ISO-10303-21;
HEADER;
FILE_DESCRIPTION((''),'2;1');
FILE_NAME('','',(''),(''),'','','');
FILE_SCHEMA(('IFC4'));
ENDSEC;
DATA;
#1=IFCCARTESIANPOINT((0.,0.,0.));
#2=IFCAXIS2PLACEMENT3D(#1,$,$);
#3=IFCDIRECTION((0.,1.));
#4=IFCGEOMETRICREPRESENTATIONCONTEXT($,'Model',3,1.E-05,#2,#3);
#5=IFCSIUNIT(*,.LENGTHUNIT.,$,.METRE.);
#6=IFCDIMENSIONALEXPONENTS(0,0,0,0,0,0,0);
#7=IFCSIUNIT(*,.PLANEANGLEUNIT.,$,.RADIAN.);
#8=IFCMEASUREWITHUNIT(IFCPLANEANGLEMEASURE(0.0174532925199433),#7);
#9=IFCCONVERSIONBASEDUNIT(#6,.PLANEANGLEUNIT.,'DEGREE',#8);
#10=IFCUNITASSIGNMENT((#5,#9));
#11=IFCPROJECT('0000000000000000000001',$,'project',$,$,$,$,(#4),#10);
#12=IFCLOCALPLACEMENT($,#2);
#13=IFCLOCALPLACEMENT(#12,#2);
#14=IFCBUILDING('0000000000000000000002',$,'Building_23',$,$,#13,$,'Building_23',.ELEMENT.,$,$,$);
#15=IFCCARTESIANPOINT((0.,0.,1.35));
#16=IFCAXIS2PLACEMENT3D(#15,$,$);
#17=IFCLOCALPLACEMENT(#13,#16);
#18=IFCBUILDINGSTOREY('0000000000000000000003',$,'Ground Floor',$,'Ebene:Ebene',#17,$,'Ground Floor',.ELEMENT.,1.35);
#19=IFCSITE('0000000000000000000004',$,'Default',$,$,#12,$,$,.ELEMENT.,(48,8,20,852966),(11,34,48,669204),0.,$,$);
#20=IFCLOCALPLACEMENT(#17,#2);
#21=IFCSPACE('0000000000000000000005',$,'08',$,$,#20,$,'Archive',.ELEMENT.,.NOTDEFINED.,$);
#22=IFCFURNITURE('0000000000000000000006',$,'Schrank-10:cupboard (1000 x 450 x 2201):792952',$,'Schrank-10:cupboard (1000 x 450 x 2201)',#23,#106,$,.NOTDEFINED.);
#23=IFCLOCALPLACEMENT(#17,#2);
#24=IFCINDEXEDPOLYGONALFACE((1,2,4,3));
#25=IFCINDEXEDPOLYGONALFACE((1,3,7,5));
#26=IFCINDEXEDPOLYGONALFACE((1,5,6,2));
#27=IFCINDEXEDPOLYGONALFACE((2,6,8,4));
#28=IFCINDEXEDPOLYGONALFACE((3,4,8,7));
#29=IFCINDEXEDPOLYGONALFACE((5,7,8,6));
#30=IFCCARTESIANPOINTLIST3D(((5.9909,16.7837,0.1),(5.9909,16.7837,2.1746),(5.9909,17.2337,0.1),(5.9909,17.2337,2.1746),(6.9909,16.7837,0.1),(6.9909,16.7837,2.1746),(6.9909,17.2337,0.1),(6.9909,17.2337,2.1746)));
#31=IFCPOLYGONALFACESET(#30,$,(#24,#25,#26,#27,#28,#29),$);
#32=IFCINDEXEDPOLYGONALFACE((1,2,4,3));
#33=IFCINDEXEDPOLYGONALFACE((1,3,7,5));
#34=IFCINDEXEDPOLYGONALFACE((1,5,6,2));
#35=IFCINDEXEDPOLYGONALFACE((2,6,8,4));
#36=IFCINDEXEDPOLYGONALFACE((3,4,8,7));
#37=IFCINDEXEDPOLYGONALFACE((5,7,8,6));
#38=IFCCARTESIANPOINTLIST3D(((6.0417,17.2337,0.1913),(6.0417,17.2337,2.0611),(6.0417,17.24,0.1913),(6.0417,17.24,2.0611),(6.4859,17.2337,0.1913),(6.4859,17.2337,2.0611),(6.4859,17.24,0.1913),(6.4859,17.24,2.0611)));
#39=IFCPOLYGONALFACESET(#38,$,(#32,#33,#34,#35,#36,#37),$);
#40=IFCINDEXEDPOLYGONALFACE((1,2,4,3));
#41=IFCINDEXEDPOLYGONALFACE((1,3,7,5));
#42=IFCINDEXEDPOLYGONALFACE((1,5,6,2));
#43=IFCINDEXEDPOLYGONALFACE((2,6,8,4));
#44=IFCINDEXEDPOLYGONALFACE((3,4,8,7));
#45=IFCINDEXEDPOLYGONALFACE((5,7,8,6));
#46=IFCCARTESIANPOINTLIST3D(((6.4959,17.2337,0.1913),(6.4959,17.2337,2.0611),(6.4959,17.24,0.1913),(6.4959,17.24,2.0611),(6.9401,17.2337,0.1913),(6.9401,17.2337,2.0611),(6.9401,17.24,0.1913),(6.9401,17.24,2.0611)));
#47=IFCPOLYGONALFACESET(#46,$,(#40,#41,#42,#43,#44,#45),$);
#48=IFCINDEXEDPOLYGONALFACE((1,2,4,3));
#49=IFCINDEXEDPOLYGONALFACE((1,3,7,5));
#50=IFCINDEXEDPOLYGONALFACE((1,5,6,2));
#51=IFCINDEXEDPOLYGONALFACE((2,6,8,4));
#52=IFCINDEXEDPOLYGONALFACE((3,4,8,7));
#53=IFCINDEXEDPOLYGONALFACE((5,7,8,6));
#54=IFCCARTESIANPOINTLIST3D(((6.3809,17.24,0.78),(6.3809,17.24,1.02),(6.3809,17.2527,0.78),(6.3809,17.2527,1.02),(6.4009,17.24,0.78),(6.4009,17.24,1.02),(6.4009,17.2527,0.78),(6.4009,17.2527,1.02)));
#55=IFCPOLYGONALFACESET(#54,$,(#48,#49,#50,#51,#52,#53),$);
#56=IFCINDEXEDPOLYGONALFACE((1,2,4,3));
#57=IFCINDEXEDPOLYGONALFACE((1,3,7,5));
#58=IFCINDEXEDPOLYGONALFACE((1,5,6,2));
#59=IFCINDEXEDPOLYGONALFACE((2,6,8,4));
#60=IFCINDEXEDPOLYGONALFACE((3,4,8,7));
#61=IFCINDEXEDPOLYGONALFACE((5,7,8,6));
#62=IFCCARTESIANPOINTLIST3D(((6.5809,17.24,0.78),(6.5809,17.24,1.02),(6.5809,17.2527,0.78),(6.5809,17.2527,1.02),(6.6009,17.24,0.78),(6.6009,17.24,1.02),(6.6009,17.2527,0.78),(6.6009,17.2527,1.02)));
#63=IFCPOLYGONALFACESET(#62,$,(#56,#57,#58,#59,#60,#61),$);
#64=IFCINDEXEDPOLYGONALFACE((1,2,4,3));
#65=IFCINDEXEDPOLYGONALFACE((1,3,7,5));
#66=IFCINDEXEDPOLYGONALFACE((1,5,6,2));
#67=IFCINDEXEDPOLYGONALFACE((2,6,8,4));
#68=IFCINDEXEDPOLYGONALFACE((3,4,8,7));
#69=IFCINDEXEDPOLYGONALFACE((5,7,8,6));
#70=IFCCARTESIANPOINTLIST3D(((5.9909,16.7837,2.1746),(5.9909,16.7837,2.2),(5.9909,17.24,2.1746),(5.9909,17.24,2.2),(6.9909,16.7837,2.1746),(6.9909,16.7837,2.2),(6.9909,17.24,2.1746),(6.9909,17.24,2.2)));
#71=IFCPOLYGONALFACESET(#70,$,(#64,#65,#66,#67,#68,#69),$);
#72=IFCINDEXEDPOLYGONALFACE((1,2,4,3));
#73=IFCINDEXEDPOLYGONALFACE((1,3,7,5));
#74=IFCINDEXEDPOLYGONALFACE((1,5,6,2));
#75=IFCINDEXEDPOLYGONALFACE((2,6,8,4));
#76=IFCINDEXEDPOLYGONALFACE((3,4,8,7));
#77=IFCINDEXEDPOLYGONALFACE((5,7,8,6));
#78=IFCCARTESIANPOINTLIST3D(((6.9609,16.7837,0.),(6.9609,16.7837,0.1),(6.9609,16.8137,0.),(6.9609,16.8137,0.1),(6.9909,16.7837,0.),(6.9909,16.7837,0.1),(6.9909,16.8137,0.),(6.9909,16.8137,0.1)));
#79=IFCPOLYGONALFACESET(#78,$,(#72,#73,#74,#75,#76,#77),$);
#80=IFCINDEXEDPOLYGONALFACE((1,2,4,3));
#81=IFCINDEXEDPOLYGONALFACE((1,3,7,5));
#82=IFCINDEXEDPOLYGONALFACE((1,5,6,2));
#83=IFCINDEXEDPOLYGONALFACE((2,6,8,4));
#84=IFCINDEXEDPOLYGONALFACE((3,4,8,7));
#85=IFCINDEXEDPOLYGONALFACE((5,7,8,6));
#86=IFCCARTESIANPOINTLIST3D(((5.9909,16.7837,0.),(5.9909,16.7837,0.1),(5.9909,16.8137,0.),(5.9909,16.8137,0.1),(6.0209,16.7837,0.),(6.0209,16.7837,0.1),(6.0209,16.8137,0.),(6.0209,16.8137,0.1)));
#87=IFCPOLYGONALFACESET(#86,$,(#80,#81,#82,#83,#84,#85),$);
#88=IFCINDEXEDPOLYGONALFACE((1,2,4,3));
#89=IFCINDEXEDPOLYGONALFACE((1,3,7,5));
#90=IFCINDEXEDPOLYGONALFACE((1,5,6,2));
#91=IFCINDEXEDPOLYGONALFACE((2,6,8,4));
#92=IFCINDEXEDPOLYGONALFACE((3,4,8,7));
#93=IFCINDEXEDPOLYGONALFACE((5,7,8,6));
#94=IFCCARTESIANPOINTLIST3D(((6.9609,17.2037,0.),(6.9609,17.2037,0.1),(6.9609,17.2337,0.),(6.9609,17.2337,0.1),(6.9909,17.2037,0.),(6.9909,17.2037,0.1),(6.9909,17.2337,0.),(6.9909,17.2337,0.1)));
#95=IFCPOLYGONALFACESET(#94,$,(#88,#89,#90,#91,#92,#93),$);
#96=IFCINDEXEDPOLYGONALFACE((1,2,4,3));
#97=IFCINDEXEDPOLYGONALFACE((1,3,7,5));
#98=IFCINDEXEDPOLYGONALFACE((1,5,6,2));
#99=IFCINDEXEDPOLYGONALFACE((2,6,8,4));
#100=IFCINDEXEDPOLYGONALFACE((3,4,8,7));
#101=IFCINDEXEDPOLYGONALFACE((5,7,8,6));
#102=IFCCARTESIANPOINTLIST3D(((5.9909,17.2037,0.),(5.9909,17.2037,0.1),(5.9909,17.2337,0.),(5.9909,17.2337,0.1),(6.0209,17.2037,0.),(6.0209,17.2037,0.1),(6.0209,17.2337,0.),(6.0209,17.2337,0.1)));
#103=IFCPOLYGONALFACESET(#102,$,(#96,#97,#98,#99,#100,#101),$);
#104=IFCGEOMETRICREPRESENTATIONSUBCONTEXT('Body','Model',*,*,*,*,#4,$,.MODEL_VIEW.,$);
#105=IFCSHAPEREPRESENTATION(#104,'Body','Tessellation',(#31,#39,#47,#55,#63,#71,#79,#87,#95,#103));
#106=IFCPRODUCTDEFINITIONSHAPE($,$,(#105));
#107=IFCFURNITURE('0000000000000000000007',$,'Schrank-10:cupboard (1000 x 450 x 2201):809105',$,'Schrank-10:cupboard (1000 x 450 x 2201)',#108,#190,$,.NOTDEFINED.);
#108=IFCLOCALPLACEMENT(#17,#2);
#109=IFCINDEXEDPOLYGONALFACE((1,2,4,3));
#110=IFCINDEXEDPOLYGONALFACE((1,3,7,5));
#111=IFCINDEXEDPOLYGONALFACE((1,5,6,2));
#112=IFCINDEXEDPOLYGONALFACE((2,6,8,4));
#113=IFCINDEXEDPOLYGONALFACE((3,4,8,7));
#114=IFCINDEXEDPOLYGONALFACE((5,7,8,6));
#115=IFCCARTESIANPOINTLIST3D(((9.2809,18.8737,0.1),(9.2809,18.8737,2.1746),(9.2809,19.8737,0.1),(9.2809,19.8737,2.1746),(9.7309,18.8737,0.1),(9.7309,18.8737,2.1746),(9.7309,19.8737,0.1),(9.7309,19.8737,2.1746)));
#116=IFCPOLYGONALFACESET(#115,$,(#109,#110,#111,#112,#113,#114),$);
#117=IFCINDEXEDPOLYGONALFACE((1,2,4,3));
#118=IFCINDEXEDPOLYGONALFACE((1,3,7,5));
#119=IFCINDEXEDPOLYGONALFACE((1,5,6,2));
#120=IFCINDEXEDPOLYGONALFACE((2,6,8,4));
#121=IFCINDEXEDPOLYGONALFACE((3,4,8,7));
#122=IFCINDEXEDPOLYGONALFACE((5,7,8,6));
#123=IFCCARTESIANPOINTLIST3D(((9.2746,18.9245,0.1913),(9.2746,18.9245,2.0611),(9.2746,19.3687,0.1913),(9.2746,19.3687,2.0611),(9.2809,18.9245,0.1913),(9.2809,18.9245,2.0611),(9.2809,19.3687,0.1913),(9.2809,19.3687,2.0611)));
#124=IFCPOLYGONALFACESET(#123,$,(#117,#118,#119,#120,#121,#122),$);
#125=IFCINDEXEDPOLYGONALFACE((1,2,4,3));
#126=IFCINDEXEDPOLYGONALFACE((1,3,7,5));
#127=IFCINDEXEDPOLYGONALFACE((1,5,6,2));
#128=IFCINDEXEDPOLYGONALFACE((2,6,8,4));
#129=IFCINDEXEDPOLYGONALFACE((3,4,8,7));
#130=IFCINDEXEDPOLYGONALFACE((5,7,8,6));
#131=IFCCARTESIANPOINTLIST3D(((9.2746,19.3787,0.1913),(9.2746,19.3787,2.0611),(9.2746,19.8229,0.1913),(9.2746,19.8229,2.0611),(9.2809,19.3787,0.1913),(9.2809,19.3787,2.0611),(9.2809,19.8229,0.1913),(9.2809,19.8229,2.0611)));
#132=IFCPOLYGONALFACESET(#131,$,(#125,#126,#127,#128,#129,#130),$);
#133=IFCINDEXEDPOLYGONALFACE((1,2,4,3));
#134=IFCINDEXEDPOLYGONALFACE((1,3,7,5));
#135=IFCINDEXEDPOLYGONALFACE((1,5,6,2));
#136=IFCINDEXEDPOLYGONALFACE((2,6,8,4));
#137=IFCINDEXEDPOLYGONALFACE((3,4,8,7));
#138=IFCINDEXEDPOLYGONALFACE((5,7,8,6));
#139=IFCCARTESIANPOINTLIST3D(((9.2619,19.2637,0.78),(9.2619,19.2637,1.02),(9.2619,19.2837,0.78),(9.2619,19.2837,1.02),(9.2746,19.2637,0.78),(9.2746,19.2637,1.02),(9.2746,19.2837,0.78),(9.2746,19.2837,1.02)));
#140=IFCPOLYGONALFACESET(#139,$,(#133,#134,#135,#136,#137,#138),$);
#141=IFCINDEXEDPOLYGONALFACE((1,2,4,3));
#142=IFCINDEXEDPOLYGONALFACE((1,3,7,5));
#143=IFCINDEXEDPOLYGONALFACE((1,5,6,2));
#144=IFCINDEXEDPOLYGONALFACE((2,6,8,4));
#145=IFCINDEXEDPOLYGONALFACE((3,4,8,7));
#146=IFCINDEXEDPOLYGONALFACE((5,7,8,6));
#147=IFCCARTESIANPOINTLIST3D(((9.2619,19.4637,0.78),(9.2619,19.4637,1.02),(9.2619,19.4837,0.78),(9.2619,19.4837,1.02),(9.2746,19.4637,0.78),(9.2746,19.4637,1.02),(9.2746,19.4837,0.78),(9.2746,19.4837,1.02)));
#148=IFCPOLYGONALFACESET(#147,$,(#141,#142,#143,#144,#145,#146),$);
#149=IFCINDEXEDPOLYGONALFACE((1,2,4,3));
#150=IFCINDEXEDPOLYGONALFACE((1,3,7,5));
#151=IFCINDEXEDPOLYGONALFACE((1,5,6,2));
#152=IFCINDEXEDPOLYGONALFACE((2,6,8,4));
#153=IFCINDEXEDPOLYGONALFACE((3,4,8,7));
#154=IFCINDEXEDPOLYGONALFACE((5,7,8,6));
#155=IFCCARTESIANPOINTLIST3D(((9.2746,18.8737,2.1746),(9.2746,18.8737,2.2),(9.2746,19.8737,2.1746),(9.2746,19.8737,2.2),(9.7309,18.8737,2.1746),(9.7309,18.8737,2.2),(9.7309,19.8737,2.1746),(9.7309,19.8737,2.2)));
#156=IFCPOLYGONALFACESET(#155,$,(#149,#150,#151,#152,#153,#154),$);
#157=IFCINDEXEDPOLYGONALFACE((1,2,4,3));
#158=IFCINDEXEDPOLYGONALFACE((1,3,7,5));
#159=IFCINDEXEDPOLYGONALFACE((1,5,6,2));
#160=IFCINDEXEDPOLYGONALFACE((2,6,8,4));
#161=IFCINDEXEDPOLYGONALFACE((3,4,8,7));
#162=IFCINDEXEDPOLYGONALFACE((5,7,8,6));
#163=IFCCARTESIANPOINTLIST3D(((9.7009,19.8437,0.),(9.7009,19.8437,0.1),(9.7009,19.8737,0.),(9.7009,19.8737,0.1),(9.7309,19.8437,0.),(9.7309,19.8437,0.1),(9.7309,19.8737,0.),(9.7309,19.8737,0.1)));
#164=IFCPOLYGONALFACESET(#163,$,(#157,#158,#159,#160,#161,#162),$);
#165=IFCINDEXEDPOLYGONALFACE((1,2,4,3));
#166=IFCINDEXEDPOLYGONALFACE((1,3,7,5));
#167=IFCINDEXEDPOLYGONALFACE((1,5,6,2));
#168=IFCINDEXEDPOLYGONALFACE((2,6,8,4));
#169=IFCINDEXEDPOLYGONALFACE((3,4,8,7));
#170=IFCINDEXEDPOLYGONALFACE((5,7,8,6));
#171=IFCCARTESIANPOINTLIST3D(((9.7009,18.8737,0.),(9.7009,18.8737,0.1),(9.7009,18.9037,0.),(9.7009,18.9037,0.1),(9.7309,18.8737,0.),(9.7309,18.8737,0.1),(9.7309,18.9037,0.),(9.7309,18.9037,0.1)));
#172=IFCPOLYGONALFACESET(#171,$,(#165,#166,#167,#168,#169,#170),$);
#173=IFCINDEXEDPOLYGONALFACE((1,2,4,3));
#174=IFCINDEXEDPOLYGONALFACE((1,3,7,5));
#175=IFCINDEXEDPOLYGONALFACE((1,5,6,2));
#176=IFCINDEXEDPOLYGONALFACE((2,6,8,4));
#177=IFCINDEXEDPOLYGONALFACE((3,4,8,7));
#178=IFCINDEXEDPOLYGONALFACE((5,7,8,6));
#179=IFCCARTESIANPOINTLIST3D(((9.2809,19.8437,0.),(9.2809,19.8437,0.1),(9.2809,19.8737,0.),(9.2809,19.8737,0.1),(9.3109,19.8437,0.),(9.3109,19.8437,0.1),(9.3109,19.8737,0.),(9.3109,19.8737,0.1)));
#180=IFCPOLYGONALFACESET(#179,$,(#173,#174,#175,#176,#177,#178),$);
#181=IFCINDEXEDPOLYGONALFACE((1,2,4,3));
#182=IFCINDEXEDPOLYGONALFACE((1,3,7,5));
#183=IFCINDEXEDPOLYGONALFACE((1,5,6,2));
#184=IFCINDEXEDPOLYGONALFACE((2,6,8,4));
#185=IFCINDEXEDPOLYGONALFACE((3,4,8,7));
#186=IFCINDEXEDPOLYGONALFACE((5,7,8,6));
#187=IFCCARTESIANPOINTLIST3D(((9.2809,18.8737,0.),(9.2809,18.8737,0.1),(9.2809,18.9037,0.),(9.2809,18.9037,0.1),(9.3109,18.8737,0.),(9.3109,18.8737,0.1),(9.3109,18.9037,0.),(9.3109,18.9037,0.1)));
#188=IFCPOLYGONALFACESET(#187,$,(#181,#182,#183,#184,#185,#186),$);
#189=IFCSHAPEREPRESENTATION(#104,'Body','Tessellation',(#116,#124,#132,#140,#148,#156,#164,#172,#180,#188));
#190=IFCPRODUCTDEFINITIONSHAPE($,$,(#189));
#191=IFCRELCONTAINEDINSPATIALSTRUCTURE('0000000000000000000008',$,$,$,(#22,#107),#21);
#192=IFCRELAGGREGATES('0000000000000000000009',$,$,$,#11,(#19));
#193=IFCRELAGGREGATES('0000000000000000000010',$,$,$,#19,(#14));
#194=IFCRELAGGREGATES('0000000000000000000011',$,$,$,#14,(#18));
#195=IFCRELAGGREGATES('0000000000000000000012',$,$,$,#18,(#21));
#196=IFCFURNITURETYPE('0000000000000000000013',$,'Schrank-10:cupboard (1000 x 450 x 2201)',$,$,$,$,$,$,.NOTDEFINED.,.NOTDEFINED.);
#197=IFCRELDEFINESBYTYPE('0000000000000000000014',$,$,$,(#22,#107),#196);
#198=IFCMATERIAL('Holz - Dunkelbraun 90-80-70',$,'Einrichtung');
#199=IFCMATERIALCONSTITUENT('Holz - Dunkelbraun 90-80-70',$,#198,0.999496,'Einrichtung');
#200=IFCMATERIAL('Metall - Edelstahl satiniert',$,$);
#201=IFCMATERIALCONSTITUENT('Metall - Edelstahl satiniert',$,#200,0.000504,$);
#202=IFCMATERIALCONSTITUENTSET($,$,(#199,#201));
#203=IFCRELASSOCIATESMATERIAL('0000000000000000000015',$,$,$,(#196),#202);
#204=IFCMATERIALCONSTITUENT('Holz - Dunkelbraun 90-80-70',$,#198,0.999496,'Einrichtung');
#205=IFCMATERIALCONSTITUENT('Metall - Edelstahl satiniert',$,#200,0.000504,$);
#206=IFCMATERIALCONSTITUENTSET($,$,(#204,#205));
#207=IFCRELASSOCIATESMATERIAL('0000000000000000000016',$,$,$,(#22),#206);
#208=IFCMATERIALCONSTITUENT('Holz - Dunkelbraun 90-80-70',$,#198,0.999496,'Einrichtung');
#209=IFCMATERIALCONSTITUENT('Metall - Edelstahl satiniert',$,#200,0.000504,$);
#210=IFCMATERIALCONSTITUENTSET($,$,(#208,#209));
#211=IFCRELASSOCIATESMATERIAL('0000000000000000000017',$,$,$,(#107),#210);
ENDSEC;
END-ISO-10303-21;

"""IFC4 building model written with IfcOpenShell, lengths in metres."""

from ifc_helpers import new_model, entity, si_unit, converted_unit, direction, frame, origin, place, context, subcontext, project, spatial, indexed_curve, outline, extrude, source, transform, mapped, material, constituent, constituent_set, type_object, type_shapes, element, save


model = new_model("IFC4")

# Units and contexts
model_context = context("Model", 3, precision=1e-05, world=origin(), true_north=direction((0.0, 1.0)))
body_context = subcontext(model_context, "Body", "Model", "MODEL_VIEW")
ifc_project = project(units=[si_unit("LENGTHUNIT", "METRE"), converted_unit("PLANEANGLEUNIT", "DEGREE", entity("IfcPlaneAngleMeasure", 0.0174532925199433), si_unit("PLANEANGLEUNIT", "RADIAN"), dimensions=[0, 0, 0, 0, 0, 0, 0])], contexts=[model_context])

# Site, building, storey
site_placement = place(None, origin())
site = spatial("IfcSite", under=ifc_project, at=site_placement, Name="Default", CompositionType="ELEMENT", RefLatitude=(48, 8, 20, 852966), RefLongitude=(11, 34, 48, 669204), RefElevation=0.0)
building_placement = place(site_placement, origin())
building = spatial("IfcBuilding", under=site, at=building_placement, Name="Building_23", LongName="Building_23", CompositionType="ELEMENT")
storey_placement = place(building_placement, frame((0.0, 0.0, 1.35)))
storey = spatial("IfcBuildingStorey", under=building, at=storey_placement, Name="Ground Floor", ObjectType="Ebene:Ebene", LongName="Ground Floor", CompositionType="ELEMENT", Elevation=1.35)

# Shared definitions
space_placement = place(storey_placement, origin())
space = spatial("IfcSpace", under=storey, at=space_placement, Name="08", LongName="Archive", CompositionType="ELEMENT", PredefinedType="NOTDEFINED")

# Furniture
ifc_material_1 = material(Name="Holz - Dunkelbraun 90-80-70", Category="Einrichtung")
ifc_material_2 = material(Name="Metall - Edelstahl satiniert")
ifc_constituent_1 = constituent(ifc_material_1, Name="Holz - Dunkelbraun 90-80-70", Category="Einrichtung", fraction=0.999496)
ifc_constituent_2 = constituent(ifc_material_2, Name="Metall - Edelstahl satiniert", fraction=0.000504)
ifc_constituent_set_1 = constituent_set(constituents=[ifc_constituent_1, ifc_constituent_2])
furniture_type = type_object("IfcFurnitureType", Name="Schrank-10:cupboard (1000 x 450 x 2201)", AssemblyPlace="NOTDEFINED", PredefinedType="NOTDEFINED", material=ifc_constituent_set_1)
shared_shape_1 = source(origin(), body_context, "Body", "SweptSolid", [
    extrude(outline(indexed_curve([(-0.225, -0.5), (0.225, -0.5), (0.225, 0.5), (-0.225, 0.5), (-0.225, -0.5)], self_intersect=False)), frame((-0.2692, -0.3632, 0.1), z_axis=(0.0, 0.0, 1.0), x_axis=(0.0, 1.0, 0.0)), (0.0, 0.0, 1.0), 2.0746),
    extrude(outline(indexed_curve([(-0.0032, -0.2221), (0.0032, -0.2221), (0.0032, 0.2221), (-0.0032, 0.2221), (-0.0032, -0.2221)], self_intersect=False)), frame((-0.0421, -0.5913, 0.1913), z_axis=(0.0, 0.0, 1.0), x_axis=(0.0, 1.0, 0.0)), (0.0, 0.0, 1.0), 1.8698),
    extrude(outline(indexed_curve([(-0.0032, -0.2221), (0.0032, -0.2221), (0.0032, 0.2221), (-0.0032, 0.2221), (-0.0032, -0.2221)], self_intersect=False)), frame((-0.4963, -0.5913, 0.1913), z_axis=(0.0, 0.0, 1.0), x_axis=(0.0, 1.0, 0.0)), (0.0, 0.0, 1.0), 1.8698),
    extrude(outline(indexed_curve([(-0.0063, -0.01), (0.0063, -0.01), (0.0063, 0.01), (-0.0063, 0.01), (-0.0063, -0.01)], self_intersect=False)), frame((-0.1692, -0.6009, 0.78), z_axis=(0.0, 0.0, 1.0), x_axis=(0.0, 1.0, 0.0)), (0.0, 0.0, 1.0), 0.24),
    extrude(outline(indexed_curve([(-0.0063, -0.01), (0.0063, -0.01), (0.0063, 0.01), (-0.0063, 0.01), (-0.0063, -0.01)], self_intersect=False)), frame((-0.3692, -0.6009, 0.78), z_axis=(0.0, 0.0, 1.0), x_axis=(0.0, 1.0, 0.0)), (0.0, 0.0, 1.0), 0.24),
    extrude(outline(indexed_curve([(-0.5, -0.2282), (0.5, -0.2282), (0.5, 0.2282), (-0.5, 0.2282), (-0.5, -0.2282)], self_intersect=False)), frame((-0.2692, -0.3663, 2.1746), z_axis=(0.0, 0.0, 1.0), x_axis=(-1.0, 0.0, 0.0)), (0.0, 0.0, 1.0), 0.0254),
    extrude(outline(indexed_curve([(-0.015, -0.015), (0.015, -0.015), (0.015, 0.015), (-0.015, 0.015), (-0.015, -0.015)], self_intersect=False)), frame((-0.7542, -0.1532, 0.0), z_axis=(0.0, 0.0, 1.0), x_axis=(-1.0, 0.0, 0.0)), (0.0, 0.0, 1.0), 0.1),
    extrude(outline(indexed_curve([(-0.015, -0.015), (0.015, -0.015), (0.015, 0.015), (-0.015, 0.015), (-0.015, -0.015)], self_intersect=False)), frame((0.2158, -0.1532, 0.0), z_axis=(0.0, 0.0, 1.0), x_axis=(0.0, -1.0, 0.0)), (0.0, 0.0, 1.0), 0.1),
    extrude(outline(indexed_curve([(-0.015, -0.015), (0.015, -0.015), (0.015, 0.015), (-0.015, 0.015), (-0.015, -0.015)], self_intersect=False)), frame((-0.7542, -0.5732, 0.0), z_axis=(0.0, 0.0, 1.0), x_axis=(0.0, 1.0, 0.0)), (0.0, 0.0, 1.0), 0.1),
    extrude(outline(indexed_curve([(-0.015, -0.015), (0.015, -0.015), (0.015, 0.015), (-0.015, 0.015), (-0.015, -0.015)], self_intersect=False)), frame((0.2158, -0.5732, 0.0)), (0.0, 0.0, 1.0), 0.1),
])
type_shapes(furniture_type, [shared_shape_1])
ifc_constituent_3 = constituent(ifc_material_1, Name="Holz - Dunkelbraun 90-80-70", Category="Einrichtung", fraction=0.999496)
ifc_constituent_4 = constituent(ifc_material_2, Name="Metall - Edelstahl satiniert", fraction=0.000504)
ifc_constituent_set_2 = constituent_set(constituents=[ifc_constituent_3, ifc_constituent_4])
furniture_1_placement = place(space_placement, frame((6.2217, 16.6455, 0.0), z_axis=(0.0, 0.0, 1.0), x_axis=(-1.0, 0.0, 0.0)))
element("IfcFurniture", 1, at=furniture_1_placement, inside=space, type_object=furniture_type, material=ifc_constituent_set_2, Name="Schrank-10:cupboard (1000 x 450 x 2201):792952", ObjectType="Schrank-10:cupboard (1000 x 450 x 2201)", PredefinedType="NOTDEFINED", context=body_context, shape_type="MappedRepresentation", body=[
    mapped(shared_shape_1, transform((0.0, 0.0, 0.0), scale=1.0)),
])
ifc_constituent_5 = constituent(ifc_material_1, Name="Holz - Dunkelbraun 90-80-70", Category="Einrichtung", fraction=0.999496)
ifc_constituent_6 = constituent(ifc_material_2, Name="Metall - Edelstahl satiniert", fraction=0.000504)
ifc_constituent_set_3 = constituent_set(constituents=[ifc_constituent_5, ifc_constituent_6])
furniture_2_placement = place(space_placement, frame((9.8691, 19.1045, 0.0), z_axis=(0.0, 0.0, 1.0), x_axis=(0.0, -1.0, 0.0)))
element("IfcFurniture", 2, at=furniture_2_placement, inside=space, type_object=furniture_type, material=ifc_constituent_set_3, Name="Schrank-10:cupboard (1000 x 450 x 2201):809105", ObjectType="Schrank-10:cupboard (1000 x 450 x 2201)", PredefinedType="NOTDEFINED", context=body_context, shape_type="MappedRepresentation", body=[
    mapped(shared_shape_1, transform((0.0, 0.0, 0.0), scale=1.0)),
])

save(model, "model.ifc")
